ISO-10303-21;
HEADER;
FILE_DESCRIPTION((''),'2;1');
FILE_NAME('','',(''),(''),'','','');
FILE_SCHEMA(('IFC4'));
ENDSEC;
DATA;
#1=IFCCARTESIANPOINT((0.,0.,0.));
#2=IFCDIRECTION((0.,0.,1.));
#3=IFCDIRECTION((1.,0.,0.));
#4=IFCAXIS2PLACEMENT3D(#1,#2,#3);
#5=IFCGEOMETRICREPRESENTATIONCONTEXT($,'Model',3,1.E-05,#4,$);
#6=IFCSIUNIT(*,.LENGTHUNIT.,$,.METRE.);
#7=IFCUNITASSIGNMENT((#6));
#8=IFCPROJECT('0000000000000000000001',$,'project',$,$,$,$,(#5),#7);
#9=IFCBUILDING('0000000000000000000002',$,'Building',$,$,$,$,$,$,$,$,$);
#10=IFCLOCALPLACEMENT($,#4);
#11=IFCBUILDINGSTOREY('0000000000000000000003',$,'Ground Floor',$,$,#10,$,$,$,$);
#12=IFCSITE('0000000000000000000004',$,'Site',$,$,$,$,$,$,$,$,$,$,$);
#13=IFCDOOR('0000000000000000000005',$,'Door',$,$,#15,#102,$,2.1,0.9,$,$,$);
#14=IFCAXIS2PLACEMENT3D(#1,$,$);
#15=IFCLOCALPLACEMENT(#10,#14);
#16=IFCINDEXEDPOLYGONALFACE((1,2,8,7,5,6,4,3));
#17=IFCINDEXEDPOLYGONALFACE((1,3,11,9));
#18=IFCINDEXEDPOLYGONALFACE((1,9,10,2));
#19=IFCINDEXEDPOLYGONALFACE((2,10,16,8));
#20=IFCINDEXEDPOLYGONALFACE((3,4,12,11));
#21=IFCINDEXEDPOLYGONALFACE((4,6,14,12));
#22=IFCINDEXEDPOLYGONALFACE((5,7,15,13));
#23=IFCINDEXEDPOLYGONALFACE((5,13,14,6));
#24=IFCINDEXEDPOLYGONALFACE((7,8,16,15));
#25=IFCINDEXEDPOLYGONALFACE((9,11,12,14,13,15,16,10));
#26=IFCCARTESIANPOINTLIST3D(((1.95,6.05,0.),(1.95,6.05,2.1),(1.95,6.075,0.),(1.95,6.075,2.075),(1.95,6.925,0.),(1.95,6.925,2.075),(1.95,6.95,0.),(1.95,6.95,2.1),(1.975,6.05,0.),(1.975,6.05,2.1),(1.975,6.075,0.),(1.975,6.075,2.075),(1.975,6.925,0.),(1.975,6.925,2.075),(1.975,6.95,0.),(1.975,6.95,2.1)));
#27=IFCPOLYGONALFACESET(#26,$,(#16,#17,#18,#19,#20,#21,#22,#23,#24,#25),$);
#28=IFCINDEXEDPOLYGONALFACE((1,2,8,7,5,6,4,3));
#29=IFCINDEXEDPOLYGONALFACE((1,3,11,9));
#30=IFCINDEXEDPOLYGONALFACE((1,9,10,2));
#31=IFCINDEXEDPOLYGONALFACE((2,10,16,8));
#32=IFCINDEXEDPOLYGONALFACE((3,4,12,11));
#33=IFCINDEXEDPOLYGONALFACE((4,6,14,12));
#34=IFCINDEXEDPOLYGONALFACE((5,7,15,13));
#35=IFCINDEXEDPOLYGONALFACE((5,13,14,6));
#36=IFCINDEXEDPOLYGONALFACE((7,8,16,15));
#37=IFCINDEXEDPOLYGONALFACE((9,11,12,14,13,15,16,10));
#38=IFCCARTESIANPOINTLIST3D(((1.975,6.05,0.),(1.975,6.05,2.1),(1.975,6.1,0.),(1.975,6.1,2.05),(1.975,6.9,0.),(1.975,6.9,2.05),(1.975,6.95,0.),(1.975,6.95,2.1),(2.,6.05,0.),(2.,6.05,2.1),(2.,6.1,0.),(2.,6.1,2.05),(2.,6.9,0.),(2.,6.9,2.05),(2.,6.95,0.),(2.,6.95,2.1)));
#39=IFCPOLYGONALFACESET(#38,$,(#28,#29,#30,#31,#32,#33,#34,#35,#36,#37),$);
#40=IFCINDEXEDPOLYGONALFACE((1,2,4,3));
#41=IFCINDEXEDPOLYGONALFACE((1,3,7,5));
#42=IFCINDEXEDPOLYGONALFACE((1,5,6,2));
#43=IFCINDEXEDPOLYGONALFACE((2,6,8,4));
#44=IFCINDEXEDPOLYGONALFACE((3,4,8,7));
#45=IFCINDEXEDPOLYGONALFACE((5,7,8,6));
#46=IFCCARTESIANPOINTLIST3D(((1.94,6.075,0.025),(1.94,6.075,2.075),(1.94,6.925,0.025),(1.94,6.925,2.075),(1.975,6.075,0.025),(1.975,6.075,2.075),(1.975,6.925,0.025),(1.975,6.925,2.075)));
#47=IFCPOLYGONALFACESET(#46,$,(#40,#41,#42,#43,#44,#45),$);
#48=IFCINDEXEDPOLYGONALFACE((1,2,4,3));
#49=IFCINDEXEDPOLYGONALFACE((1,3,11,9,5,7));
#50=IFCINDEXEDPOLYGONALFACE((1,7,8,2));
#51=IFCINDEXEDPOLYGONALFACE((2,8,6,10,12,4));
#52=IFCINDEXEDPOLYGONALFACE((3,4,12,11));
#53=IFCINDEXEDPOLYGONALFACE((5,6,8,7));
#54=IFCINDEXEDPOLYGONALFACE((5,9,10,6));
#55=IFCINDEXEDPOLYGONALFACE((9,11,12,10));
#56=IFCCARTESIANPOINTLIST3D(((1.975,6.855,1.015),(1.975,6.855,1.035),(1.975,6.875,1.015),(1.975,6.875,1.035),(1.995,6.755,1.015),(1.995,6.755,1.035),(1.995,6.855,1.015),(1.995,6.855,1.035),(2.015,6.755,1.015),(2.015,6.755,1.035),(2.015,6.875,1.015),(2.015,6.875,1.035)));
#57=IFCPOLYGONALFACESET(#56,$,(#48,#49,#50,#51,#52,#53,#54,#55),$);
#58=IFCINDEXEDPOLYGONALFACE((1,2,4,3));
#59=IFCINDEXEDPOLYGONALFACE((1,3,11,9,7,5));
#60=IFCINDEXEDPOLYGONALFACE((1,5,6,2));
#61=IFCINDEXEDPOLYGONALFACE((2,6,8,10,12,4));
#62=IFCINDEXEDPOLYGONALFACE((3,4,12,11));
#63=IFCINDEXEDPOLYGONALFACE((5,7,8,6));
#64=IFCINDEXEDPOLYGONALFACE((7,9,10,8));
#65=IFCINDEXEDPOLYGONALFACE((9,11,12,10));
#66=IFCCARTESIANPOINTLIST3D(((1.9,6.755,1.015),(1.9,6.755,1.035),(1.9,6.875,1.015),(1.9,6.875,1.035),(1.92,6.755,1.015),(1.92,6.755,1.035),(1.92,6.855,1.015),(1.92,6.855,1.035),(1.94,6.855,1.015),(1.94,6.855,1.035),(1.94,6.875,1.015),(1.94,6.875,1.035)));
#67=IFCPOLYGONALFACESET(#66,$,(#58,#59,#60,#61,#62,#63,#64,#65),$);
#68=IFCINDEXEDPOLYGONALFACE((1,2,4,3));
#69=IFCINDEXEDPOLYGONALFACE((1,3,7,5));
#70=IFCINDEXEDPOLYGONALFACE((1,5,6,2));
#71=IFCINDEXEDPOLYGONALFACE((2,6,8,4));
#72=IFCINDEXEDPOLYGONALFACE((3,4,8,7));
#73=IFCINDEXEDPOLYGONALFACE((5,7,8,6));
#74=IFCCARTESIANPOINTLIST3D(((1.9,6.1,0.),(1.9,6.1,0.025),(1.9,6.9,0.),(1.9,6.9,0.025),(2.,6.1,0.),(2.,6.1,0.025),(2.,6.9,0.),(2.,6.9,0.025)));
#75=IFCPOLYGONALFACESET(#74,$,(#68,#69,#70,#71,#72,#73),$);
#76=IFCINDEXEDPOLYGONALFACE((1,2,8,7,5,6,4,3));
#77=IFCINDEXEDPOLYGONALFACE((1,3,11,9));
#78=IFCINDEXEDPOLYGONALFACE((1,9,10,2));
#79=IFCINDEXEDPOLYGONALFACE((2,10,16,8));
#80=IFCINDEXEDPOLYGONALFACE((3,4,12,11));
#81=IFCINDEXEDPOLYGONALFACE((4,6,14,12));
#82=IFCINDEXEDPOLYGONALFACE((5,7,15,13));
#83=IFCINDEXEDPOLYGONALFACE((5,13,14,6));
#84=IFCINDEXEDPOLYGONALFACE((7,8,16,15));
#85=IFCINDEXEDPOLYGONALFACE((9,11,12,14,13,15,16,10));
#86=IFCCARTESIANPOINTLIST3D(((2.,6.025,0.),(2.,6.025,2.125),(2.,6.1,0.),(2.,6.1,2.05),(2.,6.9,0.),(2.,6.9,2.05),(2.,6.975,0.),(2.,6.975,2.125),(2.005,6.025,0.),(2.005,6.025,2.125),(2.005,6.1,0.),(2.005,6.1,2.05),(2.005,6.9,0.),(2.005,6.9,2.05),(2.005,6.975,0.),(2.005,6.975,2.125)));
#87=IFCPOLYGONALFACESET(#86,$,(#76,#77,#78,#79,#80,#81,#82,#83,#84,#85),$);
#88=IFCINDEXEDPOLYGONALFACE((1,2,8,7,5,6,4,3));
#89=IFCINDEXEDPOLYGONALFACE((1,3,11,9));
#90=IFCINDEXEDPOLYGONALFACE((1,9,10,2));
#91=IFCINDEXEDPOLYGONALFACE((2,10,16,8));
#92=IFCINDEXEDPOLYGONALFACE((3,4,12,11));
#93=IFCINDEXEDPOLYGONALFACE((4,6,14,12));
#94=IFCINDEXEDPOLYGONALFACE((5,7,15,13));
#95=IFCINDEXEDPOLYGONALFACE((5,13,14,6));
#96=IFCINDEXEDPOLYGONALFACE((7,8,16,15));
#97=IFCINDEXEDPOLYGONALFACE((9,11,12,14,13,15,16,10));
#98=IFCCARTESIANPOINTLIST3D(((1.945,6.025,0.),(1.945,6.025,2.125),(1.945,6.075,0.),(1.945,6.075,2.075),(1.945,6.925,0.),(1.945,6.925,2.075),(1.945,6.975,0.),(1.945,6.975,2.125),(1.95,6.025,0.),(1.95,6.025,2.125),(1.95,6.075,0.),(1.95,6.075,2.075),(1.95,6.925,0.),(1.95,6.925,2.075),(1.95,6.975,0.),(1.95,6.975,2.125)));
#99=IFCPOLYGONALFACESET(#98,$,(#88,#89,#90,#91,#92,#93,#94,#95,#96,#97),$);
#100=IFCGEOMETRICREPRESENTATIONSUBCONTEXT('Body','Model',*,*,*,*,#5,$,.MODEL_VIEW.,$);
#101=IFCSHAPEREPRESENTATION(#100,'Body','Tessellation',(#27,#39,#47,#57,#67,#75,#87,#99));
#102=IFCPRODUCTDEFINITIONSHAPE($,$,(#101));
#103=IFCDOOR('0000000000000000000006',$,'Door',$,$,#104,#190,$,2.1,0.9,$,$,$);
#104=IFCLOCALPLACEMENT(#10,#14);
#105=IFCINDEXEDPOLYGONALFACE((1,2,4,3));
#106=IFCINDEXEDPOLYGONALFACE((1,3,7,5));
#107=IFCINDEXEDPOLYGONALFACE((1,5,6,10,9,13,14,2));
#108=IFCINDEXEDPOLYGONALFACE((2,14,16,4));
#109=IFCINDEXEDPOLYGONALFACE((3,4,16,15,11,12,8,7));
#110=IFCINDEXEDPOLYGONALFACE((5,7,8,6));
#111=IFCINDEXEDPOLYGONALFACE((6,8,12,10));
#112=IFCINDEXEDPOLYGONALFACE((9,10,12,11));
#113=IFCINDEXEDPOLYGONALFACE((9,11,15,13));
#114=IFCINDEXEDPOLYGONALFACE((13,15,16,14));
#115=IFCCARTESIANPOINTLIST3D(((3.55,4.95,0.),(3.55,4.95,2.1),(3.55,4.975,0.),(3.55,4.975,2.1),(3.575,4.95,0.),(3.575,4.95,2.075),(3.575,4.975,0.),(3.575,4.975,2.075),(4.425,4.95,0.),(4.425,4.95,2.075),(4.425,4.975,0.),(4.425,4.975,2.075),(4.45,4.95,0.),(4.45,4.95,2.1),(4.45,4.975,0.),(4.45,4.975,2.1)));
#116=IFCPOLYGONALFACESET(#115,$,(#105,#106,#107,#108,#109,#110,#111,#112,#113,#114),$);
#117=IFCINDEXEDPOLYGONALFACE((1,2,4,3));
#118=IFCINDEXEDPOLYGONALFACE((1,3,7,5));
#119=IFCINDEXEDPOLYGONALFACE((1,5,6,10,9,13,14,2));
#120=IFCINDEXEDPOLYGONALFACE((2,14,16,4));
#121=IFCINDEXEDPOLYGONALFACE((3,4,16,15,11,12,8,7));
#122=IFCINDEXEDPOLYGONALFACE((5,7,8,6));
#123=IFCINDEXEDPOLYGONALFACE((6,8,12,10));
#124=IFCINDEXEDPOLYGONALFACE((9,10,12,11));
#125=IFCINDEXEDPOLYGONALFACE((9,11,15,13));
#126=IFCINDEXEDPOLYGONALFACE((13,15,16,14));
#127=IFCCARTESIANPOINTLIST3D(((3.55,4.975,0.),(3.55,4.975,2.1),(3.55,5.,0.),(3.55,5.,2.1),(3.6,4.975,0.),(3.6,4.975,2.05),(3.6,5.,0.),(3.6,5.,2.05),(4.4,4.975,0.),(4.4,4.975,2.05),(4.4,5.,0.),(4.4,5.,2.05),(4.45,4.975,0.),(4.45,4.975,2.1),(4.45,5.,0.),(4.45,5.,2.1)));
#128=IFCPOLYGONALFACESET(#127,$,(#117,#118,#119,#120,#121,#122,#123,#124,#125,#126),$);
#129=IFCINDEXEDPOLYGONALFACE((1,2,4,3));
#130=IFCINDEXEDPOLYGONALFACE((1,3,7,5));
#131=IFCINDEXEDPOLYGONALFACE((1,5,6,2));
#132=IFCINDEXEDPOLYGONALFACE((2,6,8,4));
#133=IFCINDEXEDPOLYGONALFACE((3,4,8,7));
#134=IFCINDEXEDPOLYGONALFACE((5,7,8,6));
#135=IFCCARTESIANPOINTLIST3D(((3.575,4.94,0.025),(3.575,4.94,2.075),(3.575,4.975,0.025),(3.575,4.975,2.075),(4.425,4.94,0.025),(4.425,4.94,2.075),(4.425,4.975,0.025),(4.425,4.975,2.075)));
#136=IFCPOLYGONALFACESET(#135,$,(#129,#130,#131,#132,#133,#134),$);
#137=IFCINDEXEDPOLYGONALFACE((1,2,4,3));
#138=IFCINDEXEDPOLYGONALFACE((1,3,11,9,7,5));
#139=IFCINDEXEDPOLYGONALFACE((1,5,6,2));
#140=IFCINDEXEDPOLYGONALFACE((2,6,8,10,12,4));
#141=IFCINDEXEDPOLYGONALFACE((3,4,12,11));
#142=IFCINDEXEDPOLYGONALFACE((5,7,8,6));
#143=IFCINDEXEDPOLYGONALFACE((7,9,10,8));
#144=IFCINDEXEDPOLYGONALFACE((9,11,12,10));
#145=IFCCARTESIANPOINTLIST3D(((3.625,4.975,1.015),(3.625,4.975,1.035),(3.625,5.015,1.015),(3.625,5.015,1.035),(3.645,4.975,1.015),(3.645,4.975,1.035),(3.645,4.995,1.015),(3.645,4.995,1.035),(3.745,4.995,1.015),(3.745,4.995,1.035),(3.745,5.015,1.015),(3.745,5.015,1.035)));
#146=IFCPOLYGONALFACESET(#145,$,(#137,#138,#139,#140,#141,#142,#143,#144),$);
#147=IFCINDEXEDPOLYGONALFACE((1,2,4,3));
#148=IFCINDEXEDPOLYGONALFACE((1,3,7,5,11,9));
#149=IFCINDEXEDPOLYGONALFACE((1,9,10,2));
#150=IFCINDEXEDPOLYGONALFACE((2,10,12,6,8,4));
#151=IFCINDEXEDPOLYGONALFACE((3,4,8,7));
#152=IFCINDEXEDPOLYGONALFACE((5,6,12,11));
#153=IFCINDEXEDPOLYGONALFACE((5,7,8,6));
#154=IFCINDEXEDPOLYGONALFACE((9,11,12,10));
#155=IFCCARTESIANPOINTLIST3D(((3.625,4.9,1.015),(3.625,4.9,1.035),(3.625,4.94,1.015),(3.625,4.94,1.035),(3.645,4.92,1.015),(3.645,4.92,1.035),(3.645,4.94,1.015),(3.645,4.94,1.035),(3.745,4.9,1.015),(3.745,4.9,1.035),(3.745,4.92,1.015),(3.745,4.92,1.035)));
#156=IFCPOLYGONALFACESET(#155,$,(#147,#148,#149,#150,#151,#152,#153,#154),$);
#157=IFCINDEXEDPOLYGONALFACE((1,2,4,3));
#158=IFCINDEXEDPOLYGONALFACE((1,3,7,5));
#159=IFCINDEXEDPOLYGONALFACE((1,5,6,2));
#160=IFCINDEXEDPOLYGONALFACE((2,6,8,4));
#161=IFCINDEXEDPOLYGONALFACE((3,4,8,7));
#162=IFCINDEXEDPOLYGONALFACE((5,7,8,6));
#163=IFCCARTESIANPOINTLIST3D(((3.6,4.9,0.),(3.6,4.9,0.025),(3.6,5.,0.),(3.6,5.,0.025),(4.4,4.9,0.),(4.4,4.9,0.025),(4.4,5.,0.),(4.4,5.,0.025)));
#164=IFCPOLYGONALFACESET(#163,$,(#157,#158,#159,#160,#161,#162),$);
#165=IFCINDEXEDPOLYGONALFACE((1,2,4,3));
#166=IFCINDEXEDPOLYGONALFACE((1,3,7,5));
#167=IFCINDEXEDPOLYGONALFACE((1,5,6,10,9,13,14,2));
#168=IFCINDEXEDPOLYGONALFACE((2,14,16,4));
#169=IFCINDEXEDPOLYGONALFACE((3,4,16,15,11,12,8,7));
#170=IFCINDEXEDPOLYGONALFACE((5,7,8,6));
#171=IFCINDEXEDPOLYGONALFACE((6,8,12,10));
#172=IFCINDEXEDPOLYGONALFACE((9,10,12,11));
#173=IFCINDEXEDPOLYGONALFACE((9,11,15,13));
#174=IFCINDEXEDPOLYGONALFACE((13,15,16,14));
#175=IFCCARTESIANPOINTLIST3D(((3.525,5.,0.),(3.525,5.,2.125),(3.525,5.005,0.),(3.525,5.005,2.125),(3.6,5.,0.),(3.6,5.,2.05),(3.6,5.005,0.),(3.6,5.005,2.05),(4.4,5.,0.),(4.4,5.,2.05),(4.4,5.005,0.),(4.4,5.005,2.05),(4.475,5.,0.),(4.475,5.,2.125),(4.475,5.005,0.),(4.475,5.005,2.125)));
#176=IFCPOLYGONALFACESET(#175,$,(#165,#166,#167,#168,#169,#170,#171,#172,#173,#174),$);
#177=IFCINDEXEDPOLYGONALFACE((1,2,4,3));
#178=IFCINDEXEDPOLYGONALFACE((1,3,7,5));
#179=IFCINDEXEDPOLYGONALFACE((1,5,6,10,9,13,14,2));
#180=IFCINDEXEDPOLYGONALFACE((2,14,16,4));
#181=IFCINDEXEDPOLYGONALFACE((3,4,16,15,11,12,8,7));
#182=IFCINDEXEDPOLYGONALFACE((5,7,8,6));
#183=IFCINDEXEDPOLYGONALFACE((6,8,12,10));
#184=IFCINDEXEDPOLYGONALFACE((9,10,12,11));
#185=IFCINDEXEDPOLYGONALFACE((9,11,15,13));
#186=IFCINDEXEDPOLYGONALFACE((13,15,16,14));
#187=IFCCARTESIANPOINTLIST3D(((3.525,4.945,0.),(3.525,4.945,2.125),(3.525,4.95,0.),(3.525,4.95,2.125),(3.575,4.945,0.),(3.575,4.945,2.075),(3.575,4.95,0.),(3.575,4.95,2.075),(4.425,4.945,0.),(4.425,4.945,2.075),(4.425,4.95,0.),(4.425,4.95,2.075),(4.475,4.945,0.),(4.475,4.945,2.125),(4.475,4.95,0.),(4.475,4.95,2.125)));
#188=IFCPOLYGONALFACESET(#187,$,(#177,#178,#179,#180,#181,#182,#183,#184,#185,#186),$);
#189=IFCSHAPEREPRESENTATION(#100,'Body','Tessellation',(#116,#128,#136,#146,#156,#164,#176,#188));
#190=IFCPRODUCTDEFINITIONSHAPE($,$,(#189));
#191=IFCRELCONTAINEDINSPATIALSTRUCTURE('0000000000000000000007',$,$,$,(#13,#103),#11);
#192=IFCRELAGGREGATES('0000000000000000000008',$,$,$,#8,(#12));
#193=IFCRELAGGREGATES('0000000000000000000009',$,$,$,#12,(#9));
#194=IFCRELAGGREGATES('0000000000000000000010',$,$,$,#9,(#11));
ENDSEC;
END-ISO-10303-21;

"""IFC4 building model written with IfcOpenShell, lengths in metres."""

from ifc_helpers import new_model, si_unit, frame, origin_with_axes, place, context, subcontext, project, spatial, line, indexed_curve, outline, extrude, element, save


model = new_model("IFC4")

# Units and contexts
model_context = context("Model", 3, precision=1e-05, world=origin_with_axes())
body_context = subcontext(model_context, "Body", "Model", "MODEL_VIEW")
ifc_project = project(units=[si_unit("LENGTHUNIT", "METRE")], contexts=[model_context])

# Site, building, storey
site = spatial("IfcSite", under=ifc_project, Name="Site")
building = spatial("IfcBuilding", under=site, Name="Building")
storey_placement = place(None, origin_with_axes())
storey = spatial("IfcBuildingStorey", under=building, at=storey_placement, Name="Ground Floor")

# Doors
door_1_placement = place(storey_placement, frame((2.0, 6.05, 0.0), z_axis=(0.0, 0.0, 1.0), x_axis=(0.0, 1.0, 0.0)))
element("IfcDoor", 1, at=door_1_placement, inside=storey, Name="Door", OverallHeight=2.1, OverallWidth=0.9, context=body_context, shape_type="SweptSolid", body=[
    extrude(outline(indexed_curve([(0.0, 0.0), (0.0, 2.1), (0.9, 2.1), (0.9, 0.0), (0.875, 0.0), (0.875, 2.075), (0.025, 2.075), (0.025, 0.0)], segments=[line(1, 2, 3, 4, 5, 6, 7, 8, 1)])), frame((0.0, 0.025, 0.0), z_axis=(0.0, -1.0, 0.0), x_axis=(1.0, 0.0, 0.0)), (0.0, 0.0, -1.0), 0.025),
    extrude(outline(indexed_curve([(0.0, 0.0), (0.0, 2.1), (0.9, 2.1), (0.9, 0.0), (0.85, 0.0), (0.85, 2.05), (0.05, 2.05), (0.05, 0.0)], segments=[line(1, 2, 3, 4, 5, 6, 7, 8, 1)])), frame((0.0, 0.0, 0.0), z_axis=(0.0, -1.0, 0.0), x_axis=(1.0, 0.0, 0.0)), (0.0, 0.0, -1.0), 0.025),
    extrude(outline(indexed_curve([(0.0, 0.0), (0.85, 0.0), (0.85, 0.035), (0.0, 0.035)], segments=[line(1, 2, 3, 4, 1)])), frame((0.025, 0.025, 0.025), z_axis=(0.0, 0.0, 1.0), x_axis=(1.0, 0.0, 0.0)), (0.0, 0.0, 1.0), 2.05),
    extrude(outline(indexed_curve([(0.0, 0.0), (0.0, -0.04), (-0.12, -0.04), (-0.12, -0.02), (-0.02, -0.02), (-0.02, 0.0)], segments=[line(1, 2, 3, 4, 5, 6, 1)])), frame((0.825, 0.025, 1.015), z_axis=(0.0, 0.0, 1.0), x_axis=(1.0, 0.0, 0.0)), (0.0, 0.0, 1.0), 0.02),
    extrude(outline(indexed_curve([(0.0, 0.0), (0.0, 0.04), (-0.12, 0.04), (-0.12, 0.02), (-0.02, 0.02), (-0.02, 0.0)], segments=[line(1, 2, 3, 4, 5, 6, 1)])), frame((0.825, 0.06, 1.015), z_axis=(0.0, 0.0, 1.0), x_axis=(1.0, 0.0, 0.0)), (0.0, 0.0, 1.0), 0.02),
    extrude(outline(indexed_curve([(0.0, 0.0), (0.8, 0.0), (0.8, 0.1), (0.0, 0.1)], segments=[line(1, 2, 3, 4, 1)])), frame((0.05, 0.0, 0.0), z_axis=(0.0, 0.0, 1.0), x_axis=(1.0, 0.0, 0.0)), (0.0, 0.0, 1.0), 0.025),
    extrude(outline(indexed_curve([(0.0, 0.0), (0.0, 2.125), (0.95, 2.125), (0.95, 0.0), (0.875, 0.0), (0.875, 2.05), (0.075, 2.05), (0.075, 0.0)], segments=[line(1, 2, 3, 4, 5, 6, 7, 8, 1)])), frame((-0.025, -0.005, 0.0), z_axis=(0.0, -1.0, 0.0), x_axis=(1.0, 0.0, 0.0)), (0.0, 0.0, -1.0), 0.005),
    extrude(outline(indexed_curve([(0.0, 0.0), (0.0, 2.125), (0.95, 2.125), (0.95, 0.0), (0.9, 0.0), (0.9, 2.075), (0.05, 2.075), (0.05, 0.0)], segments=[line(1, 2, 3, 4, 5, 6, 7, 8, 1)])), frame((-0.025, 0.05, 0.0), z_axis=(0.0, -1.0, 0.0), x_axis=(1.0, 0.0, 0.0)), (0.0, 0.0, -1.0), 0.005),
])
door_2_placement = place(storey_placement, frame((4.45, 5.0, 0.0), z_axis=(0.0, 0.0, 1.0), x_axis=(-1.0, 0.0, 0.0)))
element("IfcDoor", 2, at=door_2_placement, inside=storey, Name="Door", OverallHeight=2.1, OverallWidth=0.9, context=body_context, shape_type="SweptSolid", body=[
    extrude(outline(indexed_curve([(0.0, 0.0), (0.0, 2.1), (0.9, 2.1), (0.9, 0.0), (0.875, 0.0), (0.875, 2.075), (0.025, 2.075), (0.025, 0.0)], segments=[line(1, 2, 3, 4, 5, 6, 7, 8, 1)])), frame((0.0, 0.025, 0.0), z_axis=(0.0, -1.0, 0.0), x_axis=(1.0, 0.0, 0.0)), (0.0, 0.0, -1.0), 0.025),
    extrude(outline(indexed_curve([(0.0, 0.0), (0.0, 2.1), (0.9, 2.1), (0.9, 0.0), (0.85, 0.0), (0.85, 2.05), (0.05, 2.05), (0.05, 0.0)], segments=[line(1, 2, 3, 4, 5, 6, 7, 8, 1)])), frame((0.0, 0.0, 0.0), z_axis=(0.0, -1.0, 0.0), x_axis=(1.0, 0.0, 0.0)), (0.0, 0.0, -1.0), 0.025),
    extrude(outline(indexed_curve([(0.0, 0.0), (0.85, 0.0), (0.85, 0.035), (0.0, 0.035)], segments=[line(1, 2, 3, 4, 1)])), frame((0.025, 0.025, 0.025), z_axis=(0.0, 0.0, 1.0), x_axis=(1.0, 0.0, 0.0)), (0.0, 0.0, 1.0), 2.05),
    extrude(outline(indexed_curve([(0.0, 0.0), (0.0, -0.04), (-0.12, -0.04), (-0.12, -0.02), (-0.02, -0.02), (-0.02, 0.0)], segments=[line(1, 2, 3, 4, 5, 6, 1)])), frame((0.825, 0.025, 1.015), z_axis=(0.0, 0.0, 1.0), x_axis=(1.0, 0.0, 0.0)), (0.0, 0.0, 1.0), 0.02),
    extrude(outline(indexed_curve([(0.0, 0.0), (0.0, 0.04), (-0.12, 0.04), (-0.12, 0.02), (-0.02, 0.02), (-0.02, 0.0)], segments=[line(1, 2, 3, 4, 5, 6, 1)])), frame((0.825, 0.06, 1.015), z_axis=(0.0, 0.0, 1.0), x_axis=(1.0, 0.0, 0.0)), (0.0, 0.0, 1.0), 0.02),
    extrude(outline(indexed_curve([(0.0, 0.0), (0.8, 0.0), (0.8, 0.1), (0.0, 0.1)], segments=[line(1, 2, 3, 4, 1)])), frame((0.05, 0.0, 0.0), z_axis=(0.0, 0.0, 1.0), x_axis=(1.0, 0.0, 0.0)), (0.0, 0.0, 1.0), 0.025),
    extrude(outline(indexed_curve([(0.0, 0.0), (0.0, 2.125), (0.95, 2.125), (0.95, 0.0), (0.875, 0.0), (0.875, 2.05), (0.075, 2.05), (0.075, 0.0)], segments=[line(1, 2, 3, 4, 5, 6, 7, 8, 1)])), frame((-0.025, -0.005, 0.0), z_axis=(0.0, -1.0, 0.0), x_axis=(1.0, 0.0, 0.0)), (0.0, 0.0, -1.0), 0.005),
    extrude(outline(indexed_curve([(0.0, 0.0), (0.0, 2.125), (0.95, 2.125), (0.95, 0.0), (0.9, 0.0), (0.9, 2.075), (0.05, 2.075), (0.05, 0.0)], segments=[line(1, 2, 3, 4, 5, 6, 7, 8, 1)])), frame((-0.025, 0.05, 0.0), z_axis=(0.0, -1.0, 0.0), x_axis=(1.0, 0.0, 0.0)), (0.0, 0.0, -1.0), 0.005),
])

save(model, "model.ifc")
